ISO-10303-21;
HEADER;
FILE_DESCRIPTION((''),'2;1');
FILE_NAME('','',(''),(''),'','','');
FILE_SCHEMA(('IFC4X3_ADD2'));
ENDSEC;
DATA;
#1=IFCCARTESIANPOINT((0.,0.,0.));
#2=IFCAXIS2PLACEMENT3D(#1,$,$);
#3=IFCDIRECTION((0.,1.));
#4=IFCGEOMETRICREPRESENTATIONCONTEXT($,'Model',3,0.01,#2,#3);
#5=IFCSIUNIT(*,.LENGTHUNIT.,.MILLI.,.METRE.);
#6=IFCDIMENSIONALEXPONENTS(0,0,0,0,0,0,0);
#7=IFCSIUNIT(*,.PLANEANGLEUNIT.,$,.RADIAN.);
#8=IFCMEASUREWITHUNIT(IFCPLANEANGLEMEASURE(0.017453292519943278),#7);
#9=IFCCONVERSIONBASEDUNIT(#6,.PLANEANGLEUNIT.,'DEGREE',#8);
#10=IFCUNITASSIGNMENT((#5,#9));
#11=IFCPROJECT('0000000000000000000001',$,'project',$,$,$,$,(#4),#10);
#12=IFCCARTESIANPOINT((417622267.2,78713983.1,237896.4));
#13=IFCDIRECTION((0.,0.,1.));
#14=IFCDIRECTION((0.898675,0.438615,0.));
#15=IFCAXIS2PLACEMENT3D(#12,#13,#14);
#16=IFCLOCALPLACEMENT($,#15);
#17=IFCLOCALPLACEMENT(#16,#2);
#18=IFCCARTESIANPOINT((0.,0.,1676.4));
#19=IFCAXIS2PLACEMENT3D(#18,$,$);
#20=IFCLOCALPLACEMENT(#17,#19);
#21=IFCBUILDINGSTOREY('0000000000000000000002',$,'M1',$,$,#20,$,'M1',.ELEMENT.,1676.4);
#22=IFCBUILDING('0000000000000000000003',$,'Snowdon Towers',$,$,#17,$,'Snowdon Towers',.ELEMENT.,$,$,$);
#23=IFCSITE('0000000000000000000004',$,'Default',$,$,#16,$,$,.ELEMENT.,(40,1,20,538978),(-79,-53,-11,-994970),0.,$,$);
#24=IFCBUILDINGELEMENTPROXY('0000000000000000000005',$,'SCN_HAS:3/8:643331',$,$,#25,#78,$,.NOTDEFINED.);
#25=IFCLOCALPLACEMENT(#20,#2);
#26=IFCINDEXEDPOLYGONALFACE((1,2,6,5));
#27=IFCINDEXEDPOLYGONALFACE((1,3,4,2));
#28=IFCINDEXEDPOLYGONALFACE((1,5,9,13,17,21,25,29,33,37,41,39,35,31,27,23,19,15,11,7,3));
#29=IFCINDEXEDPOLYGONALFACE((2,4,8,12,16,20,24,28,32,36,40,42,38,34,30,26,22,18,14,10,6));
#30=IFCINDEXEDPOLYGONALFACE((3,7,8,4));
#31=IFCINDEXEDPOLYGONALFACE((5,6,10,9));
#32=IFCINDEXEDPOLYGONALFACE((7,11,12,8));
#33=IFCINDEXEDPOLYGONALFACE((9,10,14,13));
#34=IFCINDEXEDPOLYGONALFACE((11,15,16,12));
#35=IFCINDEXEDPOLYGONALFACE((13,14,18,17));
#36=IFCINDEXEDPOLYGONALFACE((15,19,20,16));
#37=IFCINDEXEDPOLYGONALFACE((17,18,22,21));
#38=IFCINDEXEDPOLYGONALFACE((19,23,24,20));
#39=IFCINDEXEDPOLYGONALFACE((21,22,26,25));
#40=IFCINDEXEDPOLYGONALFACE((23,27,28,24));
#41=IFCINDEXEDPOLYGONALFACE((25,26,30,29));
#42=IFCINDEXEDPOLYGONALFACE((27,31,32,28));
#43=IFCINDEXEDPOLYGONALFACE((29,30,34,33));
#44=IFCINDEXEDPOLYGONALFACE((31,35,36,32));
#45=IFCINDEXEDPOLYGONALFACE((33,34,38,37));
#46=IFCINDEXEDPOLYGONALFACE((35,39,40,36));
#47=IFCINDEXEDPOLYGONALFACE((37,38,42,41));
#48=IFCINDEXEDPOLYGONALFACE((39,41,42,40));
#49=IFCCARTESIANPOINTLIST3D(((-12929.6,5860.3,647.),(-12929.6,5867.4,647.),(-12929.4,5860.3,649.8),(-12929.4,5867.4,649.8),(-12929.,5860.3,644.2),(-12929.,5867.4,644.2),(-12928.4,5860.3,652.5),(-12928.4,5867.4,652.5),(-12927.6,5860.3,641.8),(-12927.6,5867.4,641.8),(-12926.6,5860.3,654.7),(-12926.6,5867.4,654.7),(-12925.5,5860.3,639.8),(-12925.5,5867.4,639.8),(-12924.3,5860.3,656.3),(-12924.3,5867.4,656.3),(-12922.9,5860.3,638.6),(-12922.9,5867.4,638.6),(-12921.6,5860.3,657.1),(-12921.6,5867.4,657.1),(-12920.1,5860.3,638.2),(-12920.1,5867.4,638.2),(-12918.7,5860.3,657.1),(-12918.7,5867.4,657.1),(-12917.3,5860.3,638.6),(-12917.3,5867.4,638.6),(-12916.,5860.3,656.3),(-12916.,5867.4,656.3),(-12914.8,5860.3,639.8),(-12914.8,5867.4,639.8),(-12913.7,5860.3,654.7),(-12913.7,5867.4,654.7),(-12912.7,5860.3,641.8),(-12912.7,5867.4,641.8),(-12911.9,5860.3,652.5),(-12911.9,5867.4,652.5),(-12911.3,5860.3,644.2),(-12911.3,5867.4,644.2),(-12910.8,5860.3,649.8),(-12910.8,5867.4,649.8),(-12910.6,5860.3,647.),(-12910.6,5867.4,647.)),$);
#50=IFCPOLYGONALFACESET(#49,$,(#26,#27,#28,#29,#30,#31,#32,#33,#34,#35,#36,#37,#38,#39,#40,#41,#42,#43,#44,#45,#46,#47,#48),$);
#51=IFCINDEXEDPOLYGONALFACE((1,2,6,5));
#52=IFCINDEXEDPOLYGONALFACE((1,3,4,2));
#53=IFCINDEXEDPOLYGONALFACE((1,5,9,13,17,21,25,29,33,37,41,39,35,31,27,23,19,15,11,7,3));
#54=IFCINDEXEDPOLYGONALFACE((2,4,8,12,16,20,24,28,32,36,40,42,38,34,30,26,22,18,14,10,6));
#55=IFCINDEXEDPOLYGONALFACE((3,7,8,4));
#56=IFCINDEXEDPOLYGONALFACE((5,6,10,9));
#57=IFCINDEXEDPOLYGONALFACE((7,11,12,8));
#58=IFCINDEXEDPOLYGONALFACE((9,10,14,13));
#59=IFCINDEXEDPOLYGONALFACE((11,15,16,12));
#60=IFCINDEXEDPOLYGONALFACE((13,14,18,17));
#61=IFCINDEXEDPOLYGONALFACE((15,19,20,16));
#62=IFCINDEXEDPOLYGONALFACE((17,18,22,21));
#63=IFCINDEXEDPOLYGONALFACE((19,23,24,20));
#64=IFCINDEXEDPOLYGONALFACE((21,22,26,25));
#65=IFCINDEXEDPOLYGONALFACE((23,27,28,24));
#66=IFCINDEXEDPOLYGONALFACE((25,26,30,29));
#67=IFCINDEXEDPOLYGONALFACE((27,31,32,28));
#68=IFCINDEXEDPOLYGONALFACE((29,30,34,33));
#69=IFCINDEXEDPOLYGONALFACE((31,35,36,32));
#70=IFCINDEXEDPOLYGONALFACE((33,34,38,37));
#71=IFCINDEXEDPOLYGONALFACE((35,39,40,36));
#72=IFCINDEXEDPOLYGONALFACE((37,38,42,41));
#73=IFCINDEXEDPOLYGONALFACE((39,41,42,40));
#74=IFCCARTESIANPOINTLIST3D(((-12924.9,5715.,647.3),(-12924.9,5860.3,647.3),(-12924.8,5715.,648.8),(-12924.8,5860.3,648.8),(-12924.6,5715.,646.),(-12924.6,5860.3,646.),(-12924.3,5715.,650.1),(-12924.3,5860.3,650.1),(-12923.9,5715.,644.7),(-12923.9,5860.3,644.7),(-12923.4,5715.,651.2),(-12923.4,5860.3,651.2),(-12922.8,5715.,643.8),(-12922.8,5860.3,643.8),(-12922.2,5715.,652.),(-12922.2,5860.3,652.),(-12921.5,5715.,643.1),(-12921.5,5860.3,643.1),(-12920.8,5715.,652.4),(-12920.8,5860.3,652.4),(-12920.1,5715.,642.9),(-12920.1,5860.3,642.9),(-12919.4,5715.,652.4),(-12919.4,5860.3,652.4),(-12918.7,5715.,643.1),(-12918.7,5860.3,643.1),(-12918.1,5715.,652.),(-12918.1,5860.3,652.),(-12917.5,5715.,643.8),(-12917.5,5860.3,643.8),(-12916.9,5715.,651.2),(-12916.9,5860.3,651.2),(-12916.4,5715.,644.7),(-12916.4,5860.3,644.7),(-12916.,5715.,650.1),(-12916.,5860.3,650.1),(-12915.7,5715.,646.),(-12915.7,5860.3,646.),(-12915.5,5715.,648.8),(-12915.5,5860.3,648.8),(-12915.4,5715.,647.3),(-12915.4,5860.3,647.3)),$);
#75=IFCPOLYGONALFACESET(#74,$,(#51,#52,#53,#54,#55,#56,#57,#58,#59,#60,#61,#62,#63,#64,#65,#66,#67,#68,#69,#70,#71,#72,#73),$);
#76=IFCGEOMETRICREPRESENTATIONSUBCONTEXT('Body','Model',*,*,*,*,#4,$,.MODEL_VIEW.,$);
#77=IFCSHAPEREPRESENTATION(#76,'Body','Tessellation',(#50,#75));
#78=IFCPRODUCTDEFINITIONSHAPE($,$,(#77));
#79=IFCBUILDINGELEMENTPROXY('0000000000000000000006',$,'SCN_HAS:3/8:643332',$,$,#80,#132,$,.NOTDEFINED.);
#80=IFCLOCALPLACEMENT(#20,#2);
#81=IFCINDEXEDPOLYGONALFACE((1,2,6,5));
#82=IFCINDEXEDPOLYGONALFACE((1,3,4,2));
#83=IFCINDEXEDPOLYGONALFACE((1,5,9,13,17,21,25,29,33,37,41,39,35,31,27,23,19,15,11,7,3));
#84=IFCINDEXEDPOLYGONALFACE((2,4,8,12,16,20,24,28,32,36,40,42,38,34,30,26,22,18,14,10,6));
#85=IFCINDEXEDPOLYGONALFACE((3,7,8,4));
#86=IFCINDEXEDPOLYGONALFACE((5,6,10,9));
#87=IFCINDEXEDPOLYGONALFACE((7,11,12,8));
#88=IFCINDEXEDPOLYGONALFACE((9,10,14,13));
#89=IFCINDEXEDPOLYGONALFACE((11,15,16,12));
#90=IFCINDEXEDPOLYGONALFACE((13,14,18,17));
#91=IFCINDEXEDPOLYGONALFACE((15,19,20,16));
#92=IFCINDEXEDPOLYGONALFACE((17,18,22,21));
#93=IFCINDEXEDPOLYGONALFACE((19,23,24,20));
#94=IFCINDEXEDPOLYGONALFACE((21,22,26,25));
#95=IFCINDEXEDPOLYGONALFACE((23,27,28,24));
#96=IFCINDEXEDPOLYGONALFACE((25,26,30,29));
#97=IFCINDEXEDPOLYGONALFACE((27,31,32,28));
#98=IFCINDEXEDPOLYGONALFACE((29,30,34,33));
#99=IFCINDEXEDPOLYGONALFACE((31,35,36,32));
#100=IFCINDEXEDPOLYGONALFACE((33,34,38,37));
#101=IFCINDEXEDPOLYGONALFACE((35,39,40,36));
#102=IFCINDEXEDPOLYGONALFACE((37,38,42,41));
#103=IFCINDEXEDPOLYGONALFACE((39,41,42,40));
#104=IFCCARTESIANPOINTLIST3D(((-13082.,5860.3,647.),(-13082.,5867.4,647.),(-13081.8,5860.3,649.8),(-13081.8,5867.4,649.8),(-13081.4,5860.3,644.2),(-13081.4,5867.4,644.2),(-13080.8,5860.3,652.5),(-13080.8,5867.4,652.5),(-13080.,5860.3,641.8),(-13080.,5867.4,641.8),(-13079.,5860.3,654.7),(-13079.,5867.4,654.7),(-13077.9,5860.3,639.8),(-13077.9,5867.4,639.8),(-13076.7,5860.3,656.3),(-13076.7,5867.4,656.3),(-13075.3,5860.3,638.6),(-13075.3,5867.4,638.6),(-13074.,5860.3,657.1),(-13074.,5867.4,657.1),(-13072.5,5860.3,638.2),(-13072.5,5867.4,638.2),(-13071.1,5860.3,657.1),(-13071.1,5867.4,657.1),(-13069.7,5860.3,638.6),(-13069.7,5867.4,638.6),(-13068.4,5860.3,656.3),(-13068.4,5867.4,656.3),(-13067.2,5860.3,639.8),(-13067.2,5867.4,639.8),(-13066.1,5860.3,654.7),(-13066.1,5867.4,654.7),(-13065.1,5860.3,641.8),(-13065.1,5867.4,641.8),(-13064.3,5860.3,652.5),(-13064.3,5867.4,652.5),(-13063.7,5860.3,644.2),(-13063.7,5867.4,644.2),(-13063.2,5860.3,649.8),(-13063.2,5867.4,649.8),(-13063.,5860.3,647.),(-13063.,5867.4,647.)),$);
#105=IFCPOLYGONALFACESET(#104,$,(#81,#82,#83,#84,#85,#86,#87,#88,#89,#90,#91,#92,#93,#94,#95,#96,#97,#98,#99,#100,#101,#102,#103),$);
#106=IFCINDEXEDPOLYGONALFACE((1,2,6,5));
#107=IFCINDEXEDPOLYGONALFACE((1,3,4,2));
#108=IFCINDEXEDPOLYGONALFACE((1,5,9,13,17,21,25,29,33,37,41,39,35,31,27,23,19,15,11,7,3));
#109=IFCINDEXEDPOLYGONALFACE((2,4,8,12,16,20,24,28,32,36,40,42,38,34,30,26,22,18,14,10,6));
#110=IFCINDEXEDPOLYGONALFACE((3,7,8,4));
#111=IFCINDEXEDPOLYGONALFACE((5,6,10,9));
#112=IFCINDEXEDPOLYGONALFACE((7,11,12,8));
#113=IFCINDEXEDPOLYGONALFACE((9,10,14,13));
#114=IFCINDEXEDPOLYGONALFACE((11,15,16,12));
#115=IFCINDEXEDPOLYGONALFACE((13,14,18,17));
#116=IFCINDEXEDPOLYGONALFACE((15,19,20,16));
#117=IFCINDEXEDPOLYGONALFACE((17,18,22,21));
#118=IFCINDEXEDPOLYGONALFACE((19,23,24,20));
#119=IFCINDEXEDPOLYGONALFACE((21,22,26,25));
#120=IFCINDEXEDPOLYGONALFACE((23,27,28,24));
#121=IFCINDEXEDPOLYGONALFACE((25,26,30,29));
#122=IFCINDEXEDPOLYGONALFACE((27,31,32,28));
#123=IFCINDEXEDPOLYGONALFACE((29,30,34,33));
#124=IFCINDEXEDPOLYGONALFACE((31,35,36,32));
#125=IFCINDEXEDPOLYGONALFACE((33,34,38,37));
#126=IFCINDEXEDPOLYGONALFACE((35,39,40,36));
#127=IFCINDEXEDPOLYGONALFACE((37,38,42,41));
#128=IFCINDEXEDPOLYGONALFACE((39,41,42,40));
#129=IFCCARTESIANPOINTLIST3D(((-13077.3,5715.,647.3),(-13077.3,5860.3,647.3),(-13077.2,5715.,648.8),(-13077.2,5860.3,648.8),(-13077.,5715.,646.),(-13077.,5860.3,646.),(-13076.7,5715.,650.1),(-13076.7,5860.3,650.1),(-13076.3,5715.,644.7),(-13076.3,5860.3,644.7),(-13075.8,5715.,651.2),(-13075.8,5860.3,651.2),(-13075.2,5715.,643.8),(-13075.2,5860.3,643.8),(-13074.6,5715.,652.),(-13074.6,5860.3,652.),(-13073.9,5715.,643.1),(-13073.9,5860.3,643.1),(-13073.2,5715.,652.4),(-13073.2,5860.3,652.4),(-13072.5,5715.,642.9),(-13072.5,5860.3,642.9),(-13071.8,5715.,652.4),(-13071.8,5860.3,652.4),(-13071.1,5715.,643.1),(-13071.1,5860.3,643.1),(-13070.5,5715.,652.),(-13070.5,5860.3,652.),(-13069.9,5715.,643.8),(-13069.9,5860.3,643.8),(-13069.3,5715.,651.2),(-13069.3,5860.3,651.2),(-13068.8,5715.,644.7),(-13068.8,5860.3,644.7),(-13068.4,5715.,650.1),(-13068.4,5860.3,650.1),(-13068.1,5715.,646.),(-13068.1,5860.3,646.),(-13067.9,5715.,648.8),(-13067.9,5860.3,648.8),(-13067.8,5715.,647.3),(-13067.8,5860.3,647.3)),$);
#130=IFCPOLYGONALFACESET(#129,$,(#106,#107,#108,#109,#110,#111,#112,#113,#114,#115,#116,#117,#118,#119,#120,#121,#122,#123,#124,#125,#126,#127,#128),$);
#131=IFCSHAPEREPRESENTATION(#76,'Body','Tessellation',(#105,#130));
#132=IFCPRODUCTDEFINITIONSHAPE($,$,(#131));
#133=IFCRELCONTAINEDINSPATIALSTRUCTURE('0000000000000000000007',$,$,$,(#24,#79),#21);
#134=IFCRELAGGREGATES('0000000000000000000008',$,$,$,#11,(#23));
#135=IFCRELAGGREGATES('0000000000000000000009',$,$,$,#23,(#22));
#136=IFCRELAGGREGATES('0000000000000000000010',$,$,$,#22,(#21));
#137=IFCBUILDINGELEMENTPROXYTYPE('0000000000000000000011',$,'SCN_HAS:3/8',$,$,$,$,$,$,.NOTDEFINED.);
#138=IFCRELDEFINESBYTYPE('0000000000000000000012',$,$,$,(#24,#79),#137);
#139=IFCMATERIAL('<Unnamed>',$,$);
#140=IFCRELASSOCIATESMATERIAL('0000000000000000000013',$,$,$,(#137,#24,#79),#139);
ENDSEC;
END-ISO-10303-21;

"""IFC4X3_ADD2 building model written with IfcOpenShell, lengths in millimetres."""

from ifc_helpers import new_model, entity, si_unit, converted_unit, direction, frame, frame_2d, origin, place, context, subcontext, project, spatial, circle, extrude, source, transform, mapped, material, type_object, type_shapes, element, save


model = new_model("IFC4X3_ADD2")

# Units and contexts
model_context = context("Model", 3, precision=0.01, world=origin(), true_north=direction((0.0, 1.0)))
body_context = subcontext(model_context, "Body", "Model", "MODEL_VIEW")
ifc_project = project(units=[si_unit("LENGTHUNIT", "METRE", prefix="MILLI"), converted_unit("PLANEANGLEUNIT", "DEGREE", entity("IfcPlaneAngleMeasure", 0.017453292519943278), si_unit("PLANEANGLEUNIT", "RADIAN"), dimensions=[0, 0, 0, 0, 0, 0, 0])], contexts=[model_context])

# Site, building, storey
site_placement = place(None, frame((417622267.2, 78713983.1, 237896.4), z_axis=(0.0, 0.0, 1.0), x_axis=(0.898675, 0.438615, 0.0)))
site = spatial("IfcSite", under=ifc_project, at=site_placement, Name="Default", CompositionType="ELEMENT", RefLatitude=(40, 1, 20, 538978), RefLongitude=(-79, -53, -11, -994970), RefElevation=0.0)
building_placement = place(site_placement, origin())
building = spatial("IfcBuilding", under=site, at=building_placement, Name="Snowdon Towers", LongName="Snowdon Towers", CompositionType="ELEMENT")
storey_placement = place(building_placement, frame((0.0, 0.0, 1676.4)))
storey = spatial("IfcBuildingStorey", under=building, at=storey_placement, Name="M1", LongName="M1", CompositionType="ELEMENT", Elevation=1676.4)

# Building element proxies
ifc_material_1 = material(Name="<Unnamed>")
building_element_proxy_type = type_object("IfcBuildingElementProxyType", Name="SCN_HAS:3/8", PredefinedType="NOTDEFINED", material=ifc_material_1)
shared_shape_1 = source(origin(), body_context, "Body", "SweptSolid", [
    extrude(circle(Radius=9.5, at=frame_2d((0.0, 0.0), x_axis=(1.0, 0.0))), frame((0.0, 0.0, -152.4), z_axis=(0.0, 0.0, 1.0), x_axis=(0.0, -1.0, 0.0)), (0.0, 0.0, 1.0), 7.1),
    extrude(circle(Radius=4.8, at=frame_2d((0.0, 0.0), x_axis=(1.0, 0.0))), frame((0.0, 0.0, -145.3), z_axis=(0.0, 0.0, 1.0), x_axis=(0.0, -1.0, 0.0)), (0.0, 0.0, 1.0), 145.3),
])
type_shapes(building_element_proxy_type, [shared_shape_1])
for number, where, z_axis, x_axis, name in (
    (1, (-12920.1, 5715.0, 647.7), (0.0, -1.0, 0.0), (1.0, 0.0, 0.0), "SCN_HAS:3/8:643331"),
    (2, (-13072.5, 5715.0, 647.7), (0.0, -1.0, 0.0), (1.0, 0.0, 0.0), "SCN_HAS:3/8:643332"),
):
    element("IfcBuildingElementProxy", number, at=place(storey_placement, frame(where, z_axis=z_axis, x_axis=x_axis)), inside=storey, type_object=building_element_proxy_type, material=ifc_material_1, Name=name, PredefinedType="NOTDEFINED", context=body_context, shape_type="MappedRepresentation", body=[
        mapped(shared_shape_1, transform((0.0, 0.0, 0.0), scale=1.0)),
    ])

save(model, "model.ifc")
